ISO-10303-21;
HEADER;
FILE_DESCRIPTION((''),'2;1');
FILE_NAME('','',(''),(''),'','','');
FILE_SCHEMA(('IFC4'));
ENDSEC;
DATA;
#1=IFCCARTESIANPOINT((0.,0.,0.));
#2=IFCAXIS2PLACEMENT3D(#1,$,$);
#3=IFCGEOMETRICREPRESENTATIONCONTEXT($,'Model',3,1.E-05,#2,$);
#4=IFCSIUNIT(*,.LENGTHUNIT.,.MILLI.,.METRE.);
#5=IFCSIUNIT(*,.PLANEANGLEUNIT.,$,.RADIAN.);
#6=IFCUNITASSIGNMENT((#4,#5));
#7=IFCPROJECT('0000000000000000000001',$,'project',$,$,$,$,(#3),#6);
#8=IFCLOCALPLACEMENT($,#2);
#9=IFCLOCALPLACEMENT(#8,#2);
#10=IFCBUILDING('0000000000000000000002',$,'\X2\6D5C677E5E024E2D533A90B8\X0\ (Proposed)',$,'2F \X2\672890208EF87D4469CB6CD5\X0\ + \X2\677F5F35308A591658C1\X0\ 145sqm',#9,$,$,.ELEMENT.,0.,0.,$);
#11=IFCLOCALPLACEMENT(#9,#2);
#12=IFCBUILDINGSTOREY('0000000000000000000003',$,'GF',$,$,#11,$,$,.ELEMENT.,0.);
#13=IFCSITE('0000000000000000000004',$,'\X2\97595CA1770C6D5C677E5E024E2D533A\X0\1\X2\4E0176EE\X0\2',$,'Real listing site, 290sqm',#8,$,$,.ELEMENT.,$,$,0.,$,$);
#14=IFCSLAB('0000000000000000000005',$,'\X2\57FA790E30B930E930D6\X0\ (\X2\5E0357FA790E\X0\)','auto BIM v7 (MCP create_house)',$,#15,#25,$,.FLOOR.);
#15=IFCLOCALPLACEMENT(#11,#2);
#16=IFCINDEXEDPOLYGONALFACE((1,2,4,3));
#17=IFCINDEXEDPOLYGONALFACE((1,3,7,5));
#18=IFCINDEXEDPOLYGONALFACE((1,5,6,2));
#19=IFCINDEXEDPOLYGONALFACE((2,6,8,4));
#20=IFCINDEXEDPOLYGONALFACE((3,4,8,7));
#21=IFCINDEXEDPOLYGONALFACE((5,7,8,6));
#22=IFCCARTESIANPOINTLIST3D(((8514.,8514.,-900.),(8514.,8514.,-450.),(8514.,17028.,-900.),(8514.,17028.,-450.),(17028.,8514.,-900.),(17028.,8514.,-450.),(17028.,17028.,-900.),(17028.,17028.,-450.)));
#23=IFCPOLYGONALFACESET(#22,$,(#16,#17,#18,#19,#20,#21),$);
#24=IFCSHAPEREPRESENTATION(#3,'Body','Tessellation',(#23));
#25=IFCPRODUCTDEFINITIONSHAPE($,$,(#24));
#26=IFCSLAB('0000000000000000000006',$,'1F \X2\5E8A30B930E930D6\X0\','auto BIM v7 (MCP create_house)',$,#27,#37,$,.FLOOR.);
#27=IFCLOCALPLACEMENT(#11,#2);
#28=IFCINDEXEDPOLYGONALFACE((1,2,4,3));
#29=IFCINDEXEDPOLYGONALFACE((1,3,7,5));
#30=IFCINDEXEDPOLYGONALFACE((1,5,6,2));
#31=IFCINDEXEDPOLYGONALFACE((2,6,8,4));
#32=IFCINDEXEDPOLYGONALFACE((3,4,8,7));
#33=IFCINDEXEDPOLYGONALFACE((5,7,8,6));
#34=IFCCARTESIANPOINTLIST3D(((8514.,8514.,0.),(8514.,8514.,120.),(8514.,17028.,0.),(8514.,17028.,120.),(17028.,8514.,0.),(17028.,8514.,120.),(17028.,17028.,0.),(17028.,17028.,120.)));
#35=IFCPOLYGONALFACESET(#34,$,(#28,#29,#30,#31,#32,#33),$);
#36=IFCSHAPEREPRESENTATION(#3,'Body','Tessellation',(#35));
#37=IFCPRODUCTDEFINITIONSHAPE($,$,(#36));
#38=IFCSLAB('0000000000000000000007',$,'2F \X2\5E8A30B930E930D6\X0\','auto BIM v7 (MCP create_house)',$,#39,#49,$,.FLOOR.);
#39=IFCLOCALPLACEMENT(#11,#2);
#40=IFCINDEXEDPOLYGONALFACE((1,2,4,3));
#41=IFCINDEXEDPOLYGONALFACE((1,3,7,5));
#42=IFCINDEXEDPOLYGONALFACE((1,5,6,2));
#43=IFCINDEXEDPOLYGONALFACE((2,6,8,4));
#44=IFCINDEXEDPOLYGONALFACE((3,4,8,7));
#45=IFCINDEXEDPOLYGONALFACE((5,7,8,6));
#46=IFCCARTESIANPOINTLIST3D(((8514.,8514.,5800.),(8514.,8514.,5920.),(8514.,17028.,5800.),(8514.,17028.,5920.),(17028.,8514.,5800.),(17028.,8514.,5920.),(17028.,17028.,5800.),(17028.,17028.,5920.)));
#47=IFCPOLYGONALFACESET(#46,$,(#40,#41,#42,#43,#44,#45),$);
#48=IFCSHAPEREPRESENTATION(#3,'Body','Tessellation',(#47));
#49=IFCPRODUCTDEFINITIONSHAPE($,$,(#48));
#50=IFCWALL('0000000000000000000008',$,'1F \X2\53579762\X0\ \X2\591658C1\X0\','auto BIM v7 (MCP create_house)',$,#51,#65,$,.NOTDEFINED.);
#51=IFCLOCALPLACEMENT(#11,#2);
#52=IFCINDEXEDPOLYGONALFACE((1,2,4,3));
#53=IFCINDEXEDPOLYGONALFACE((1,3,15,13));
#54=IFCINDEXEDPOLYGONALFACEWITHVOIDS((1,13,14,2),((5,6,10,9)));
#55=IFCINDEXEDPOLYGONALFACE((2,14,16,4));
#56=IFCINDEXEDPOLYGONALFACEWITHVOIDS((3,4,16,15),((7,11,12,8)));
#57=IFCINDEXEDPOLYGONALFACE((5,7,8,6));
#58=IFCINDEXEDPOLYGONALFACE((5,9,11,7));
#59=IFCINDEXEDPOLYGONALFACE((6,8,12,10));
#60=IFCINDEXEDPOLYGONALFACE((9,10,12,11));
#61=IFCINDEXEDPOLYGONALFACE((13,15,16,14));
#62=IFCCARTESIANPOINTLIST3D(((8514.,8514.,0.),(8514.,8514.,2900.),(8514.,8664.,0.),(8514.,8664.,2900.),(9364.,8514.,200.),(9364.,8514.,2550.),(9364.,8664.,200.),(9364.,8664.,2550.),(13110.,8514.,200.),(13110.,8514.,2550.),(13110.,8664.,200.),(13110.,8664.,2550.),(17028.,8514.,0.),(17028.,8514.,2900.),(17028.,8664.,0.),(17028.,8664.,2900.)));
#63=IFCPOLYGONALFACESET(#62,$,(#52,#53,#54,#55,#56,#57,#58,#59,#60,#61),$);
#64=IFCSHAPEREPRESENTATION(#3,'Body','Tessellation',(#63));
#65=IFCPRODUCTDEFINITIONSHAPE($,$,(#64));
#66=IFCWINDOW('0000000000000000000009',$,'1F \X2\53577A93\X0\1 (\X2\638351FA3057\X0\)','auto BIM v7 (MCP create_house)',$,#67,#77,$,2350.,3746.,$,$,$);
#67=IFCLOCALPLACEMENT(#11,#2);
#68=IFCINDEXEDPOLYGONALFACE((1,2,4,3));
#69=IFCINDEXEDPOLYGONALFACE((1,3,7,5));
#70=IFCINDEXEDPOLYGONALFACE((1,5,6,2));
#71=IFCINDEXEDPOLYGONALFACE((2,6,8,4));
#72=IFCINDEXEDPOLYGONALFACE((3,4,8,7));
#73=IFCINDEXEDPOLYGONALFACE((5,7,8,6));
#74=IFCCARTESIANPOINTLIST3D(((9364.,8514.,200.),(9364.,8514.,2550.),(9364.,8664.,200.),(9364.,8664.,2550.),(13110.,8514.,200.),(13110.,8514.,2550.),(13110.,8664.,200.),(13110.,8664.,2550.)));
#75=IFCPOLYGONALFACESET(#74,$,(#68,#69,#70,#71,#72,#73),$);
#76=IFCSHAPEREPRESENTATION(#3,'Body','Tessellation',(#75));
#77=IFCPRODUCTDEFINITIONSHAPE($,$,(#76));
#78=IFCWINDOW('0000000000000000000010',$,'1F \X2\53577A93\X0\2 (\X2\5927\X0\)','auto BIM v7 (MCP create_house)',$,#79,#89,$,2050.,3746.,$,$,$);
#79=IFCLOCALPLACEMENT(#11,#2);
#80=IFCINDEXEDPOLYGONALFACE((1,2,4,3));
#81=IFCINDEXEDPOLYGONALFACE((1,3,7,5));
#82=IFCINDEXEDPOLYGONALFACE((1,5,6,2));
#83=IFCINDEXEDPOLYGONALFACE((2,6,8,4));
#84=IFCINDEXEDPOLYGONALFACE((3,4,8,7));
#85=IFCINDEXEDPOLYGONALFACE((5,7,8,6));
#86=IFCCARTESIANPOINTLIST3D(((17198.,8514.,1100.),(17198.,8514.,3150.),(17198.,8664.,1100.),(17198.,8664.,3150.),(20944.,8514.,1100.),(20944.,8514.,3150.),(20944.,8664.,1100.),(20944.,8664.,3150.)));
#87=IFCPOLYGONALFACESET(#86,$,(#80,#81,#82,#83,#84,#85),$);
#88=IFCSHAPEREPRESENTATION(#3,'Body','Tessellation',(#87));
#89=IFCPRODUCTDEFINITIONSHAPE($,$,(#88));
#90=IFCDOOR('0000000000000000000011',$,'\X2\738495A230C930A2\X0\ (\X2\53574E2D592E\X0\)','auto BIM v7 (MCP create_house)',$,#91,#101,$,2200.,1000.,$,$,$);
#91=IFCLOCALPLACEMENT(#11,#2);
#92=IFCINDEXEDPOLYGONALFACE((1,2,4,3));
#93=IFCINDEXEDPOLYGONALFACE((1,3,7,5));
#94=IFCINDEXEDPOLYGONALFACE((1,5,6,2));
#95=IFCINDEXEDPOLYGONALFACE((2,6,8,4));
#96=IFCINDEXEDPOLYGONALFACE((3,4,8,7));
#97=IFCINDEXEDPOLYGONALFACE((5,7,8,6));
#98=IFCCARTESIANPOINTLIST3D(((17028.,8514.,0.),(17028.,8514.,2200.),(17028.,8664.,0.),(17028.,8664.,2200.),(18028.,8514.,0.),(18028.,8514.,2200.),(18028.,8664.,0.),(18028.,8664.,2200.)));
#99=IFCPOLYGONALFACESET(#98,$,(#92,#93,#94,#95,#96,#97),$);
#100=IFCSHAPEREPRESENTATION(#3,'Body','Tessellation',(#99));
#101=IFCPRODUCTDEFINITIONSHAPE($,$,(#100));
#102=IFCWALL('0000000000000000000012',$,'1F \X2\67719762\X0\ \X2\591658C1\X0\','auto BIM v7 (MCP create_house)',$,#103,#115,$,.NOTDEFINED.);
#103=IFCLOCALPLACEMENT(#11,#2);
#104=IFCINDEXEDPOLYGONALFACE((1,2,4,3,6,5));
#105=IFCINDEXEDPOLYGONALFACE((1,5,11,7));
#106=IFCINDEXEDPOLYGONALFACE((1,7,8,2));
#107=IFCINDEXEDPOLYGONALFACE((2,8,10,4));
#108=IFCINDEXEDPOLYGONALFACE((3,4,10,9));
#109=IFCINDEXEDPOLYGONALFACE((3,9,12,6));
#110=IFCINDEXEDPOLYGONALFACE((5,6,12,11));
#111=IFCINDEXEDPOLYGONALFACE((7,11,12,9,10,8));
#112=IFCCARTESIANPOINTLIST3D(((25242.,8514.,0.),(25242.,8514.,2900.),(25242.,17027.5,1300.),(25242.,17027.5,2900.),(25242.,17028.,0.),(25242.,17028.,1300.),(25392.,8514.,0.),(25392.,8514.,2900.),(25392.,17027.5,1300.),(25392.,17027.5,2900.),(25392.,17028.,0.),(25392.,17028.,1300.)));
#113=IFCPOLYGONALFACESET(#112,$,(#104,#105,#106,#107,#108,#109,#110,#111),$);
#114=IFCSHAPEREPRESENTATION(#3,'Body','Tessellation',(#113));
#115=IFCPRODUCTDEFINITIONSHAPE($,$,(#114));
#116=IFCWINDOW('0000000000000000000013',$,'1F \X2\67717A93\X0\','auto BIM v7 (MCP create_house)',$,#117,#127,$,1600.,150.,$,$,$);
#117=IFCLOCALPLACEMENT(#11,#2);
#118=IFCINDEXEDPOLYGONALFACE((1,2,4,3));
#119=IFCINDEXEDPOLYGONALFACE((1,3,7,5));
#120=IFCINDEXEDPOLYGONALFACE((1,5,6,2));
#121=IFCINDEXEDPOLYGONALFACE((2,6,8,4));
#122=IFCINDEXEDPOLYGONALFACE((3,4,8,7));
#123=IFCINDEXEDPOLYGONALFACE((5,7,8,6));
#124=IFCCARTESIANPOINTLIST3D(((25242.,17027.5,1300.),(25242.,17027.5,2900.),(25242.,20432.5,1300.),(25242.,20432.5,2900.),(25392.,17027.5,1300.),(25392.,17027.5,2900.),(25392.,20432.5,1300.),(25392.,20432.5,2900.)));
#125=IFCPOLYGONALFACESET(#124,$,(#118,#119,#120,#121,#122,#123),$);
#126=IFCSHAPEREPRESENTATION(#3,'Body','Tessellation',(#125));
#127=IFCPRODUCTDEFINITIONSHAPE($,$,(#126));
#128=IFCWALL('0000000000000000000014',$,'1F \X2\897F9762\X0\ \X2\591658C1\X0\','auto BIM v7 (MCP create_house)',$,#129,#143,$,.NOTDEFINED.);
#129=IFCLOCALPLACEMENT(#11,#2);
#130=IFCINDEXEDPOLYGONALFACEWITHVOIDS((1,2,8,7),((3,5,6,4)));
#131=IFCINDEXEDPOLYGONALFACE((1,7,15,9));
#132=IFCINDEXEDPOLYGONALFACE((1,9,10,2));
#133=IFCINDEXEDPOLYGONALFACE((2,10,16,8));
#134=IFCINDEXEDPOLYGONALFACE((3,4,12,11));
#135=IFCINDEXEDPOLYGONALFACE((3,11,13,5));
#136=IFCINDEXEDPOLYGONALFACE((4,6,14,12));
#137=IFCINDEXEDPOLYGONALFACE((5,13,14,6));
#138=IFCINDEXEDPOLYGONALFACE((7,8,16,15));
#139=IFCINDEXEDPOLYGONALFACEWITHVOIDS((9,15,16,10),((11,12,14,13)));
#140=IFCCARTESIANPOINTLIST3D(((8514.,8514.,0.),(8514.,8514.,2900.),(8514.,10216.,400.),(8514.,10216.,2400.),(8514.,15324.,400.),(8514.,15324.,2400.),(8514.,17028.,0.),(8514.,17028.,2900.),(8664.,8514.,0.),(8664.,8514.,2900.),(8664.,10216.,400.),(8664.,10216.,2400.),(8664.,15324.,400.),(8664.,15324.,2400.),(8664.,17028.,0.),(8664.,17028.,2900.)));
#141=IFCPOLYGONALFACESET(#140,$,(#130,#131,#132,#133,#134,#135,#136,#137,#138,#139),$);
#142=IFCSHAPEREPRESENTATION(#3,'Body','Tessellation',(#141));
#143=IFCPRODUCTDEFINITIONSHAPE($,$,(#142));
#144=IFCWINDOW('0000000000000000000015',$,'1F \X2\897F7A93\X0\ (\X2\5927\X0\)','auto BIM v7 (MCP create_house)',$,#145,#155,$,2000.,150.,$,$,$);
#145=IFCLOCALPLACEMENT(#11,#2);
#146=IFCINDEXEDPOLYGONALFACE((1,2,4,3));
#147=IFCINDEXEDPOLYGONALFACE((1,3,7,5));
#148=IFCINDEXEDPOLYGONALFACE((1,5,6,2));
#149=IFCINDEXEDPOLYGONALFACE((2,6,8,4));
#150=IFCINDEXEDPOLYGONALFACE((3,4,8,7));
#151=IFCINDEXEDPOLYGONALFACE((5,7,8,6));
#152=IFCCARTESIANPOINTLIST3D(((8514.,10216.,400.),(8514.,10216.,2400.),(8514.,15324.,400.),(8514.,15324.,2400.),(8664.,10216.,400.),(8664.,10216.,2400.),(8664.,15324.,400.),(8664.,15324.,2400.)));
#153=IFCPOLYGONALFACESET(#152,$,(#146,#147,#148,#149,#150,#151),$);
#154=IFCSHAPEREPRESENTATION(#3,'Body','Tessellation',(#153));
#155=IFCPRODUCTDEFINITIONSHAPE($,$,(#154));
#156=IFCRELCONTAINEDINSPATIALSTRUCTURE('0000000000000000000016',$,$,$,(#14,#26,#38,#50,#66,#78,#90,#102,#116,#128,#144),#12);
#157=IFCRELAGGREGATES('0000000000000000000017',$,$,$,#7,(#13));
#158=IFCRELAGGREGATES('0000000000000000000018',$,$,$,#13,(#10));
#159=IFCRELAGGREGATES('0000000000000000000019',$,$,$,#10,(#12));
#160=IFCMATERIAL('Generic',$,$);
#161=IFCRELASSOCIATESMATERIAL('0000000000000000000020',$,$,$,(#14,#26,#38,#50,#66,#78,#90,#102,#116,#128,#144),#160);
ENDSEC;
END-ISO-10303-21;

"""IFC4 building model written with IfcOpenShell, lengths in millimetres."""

from ifc_helpers import new_model, si_unit, frame, frame_2d, origin, place, context, project, spatial, rectangle, extrude, material, element, fill, save


model = new_model("IFC4")

# Units and contexts
model_context = context("Model", 3, precision=1e-05, world=origin())
ifc_project = project(units=[si_unit("LENGTHUNIT", "METRE", prefix="MILLI"), si_unit("PLANEANGLEUNIT", "RADIAN")], contexts=[model_context])

# Site, building, storey
site_placement = place(None, origin())
site = spatial("IfcSite", under=ifc_project, at=site_placement, Name="静岡県浜松市中区1丁目2", ObjectType="Real listing site, 290sqm", CompositionType="ELEMENT", RefElevation=0.0)
building_placement = place(site_placement, origin())
building = spatial("IfcBuilding", under=site, at=building_placement, Name="浜松市中区邸 (Proposed)", ObjectType="2F 木造軸組構法 + 板張り外壁 145sqm", CompositionType="ELEMENT", ElevationOfRefHeight=0.0, ElevationOfTerrain=0.0)
storey_placement = place(building_placement, origin())
storey = spatial("IfcBuildingStorey", under=building, at=storey_placement, Name="GF", CompositionType="ELEMENT", Elevation=0.0)

# Slabs
ifc_material = material(Name="Generic")
slab_1_placement = place(storey_placement, frame((4257.0, 4257.0, -450.0)))
element("IfcSlab", 1, at=slab_1_placement, inside=storey, material=ifc_material, Name="基礎スラブ (布基礎)", Description="auto BIM v7 (MCP create_house)", PredefinedType="FLOOR", context=model_context, shape_type="SweptSolid", body=[
    extrude(rectangle(XDim=8514.0, YDim=8514.0, at=frame_2d((4257.0, 4257.0))), frame((4257.0, 4257.0, -450.0)), (0.0, 0.0, 1.0), 450.0),
])
slab_2_placement = place(storey_placement, frame((4257.0, 4257.0, 0.0)))
element("IfcSlab", 2, at=slab_2_placement, inside=storey, material=ifc_material, Name="1F 床スラブ", Description="auto BIM v7 (MCP create_house)", PredefinedType="FLOOR", context=model_context, shape_type="SweptSolid", body=[
    extrude(rectangle(XDim=8514.0, YDim=8514.0, at=frame_2d((4257.0, 4257.0))), frame((4257.0, 4257.0, 0.0)), (0.0, 0.0, 1.0), 120.0),
])
slab_3_placement = place(storey_placement, frame((4257.0, 4257.0, 2900.0)))
element("IfcSlab", 3, at=slab_3_placement, inside=storey, material=ifc_material, Name="2F 床スラブ", Description="auto BIM v7 (MCP create_house)", PredefinedType="FLOOR", context=model_context, shape_type="SweptSolid", body=[
    extrude(rectangle(XDim=8514.0, YDim=8514.0, at=frame_2d((4257.0, 4257.0))), frame((4257.0, 4257.0, 2900.0)), (0.0, 0.0, 1.0), 120.0),
])

# Wall, openings, windows, door
wall_1_placement = place(storey_placement, frame((4257.0, 4257.0, 0.0)))
wall_1 = element("IfcWall", 4, at=wall_1_placement, inside=storey, material=ifc_material, Name="1F 南面 外壁", Description="auto BIM v7 (MCP create_house)", PredefinedType="NOTDEFINED", context=model_context, shape_type="SweptSolid", body=[
    extrude(rectangle(XDim=8514.0, YDim=150.0, at=frame_2d((4257.0, 75.0))), frame((4257.0, 4257.0, 0.0)), (0.0, 0.0, 1.0), 2900.0),
])
opening_1_placement = place(storey_placement, frame((4682.0, 4257.0, 100.0)))
opening_1 = element("IfcOpeningElement", 5, at=opening_1_placement, cuts=wall_1, PredefinedType="NOTDEFINED", context=model_context, shape_type="SweptSolid", body=[
    extrude(rectangle(XDim=3746.0, YDim=150.0, at=frame_2d((1873.0, 75.0))), frame((4682.0, 4257.0, 100.0)), (0.0, 0.0, 1.0), 2350.0),
])
opening_2_placement = place(storey_placement, frame((8599.0, 4257.0, 550.0)))
opening_2 = element("IfcOpeningElement", 6, at=opening_2_placement, cuts=wall_1, PredefinedType="NOTDEFINED", context=model_context, shape_type="SweptSolid", body=[
    extrude(rectangle(XDim=3746.0, YDim=150.0, at=frame_2d((1873.0, 75.0))), frame((8599.0, 4257.0, 550.0)), (0.0, 0.0, 1.0), 2050.0),
])
opening_3_placement = place(storey_placement, frame((8514.0, 4257.0, 0.0)))
opening_3 = element("IfcOpeningElement", 7, at=opening_3_placement, cuts=wall_1, PredefinedType="NOTDEFINED", context=model_context, shape_type="SweptSolid", body=[
    extrude(rectangle(XDim=1000.0, YDim=150.0, at=frame_2d((500.0, 75.0))), frame((8514.0, 4257.0, 0.0)), (0.0, 0.0, 1.0), 2200.0),
])
window_1_placement = place(storey_placement, frame((4682.0, 4257.0, 100.0)))
window_1 = element("IfcWindow", 8, at=window_1_placement, inside=storey, material=ifc_material, Name="1F 南窓1 (掃出し)", Description="auto BIM v7 (MCP create_house)", OverallHeight=2350.0, OverallWidth=3746.0, context=model_context, shape_type="SweptSolid", body=[
    extrude(rectangle(XDim=3746.0, YDim=150.0, at=frame_2d((1873.0, 75.0))), frame((4682.0, 4257.0, 100.0)), (0.0, 0.0, 1.0), 2350.0),
])
fill(opening_1, window_1)
window_2_placement = place(storey_placement, frame((8599.0, 4257.0, 550.0)))
window_2 = element("IfcWindow", 9, at=window_2_placement, inside=storey, material=ifc_material, Name="1F 南窓2 (大)", Description="auto BIM v7 (MCP create_house)", OverallHeight=2050.0, OverallWidth=3746.0, context=model_context, shape_type="SweptSolid", body=[
    extrude(rectangle(XDim=3746.0, YDim=150.0, at=frame_2d((1873.0, 75.0))), frame((8599.0, 4257.0, 550.0)), (0.0, 0.0, 1.0), 2050.0),
])
fill(opening_2, window_2)
door_placement = place(storey_placement, frame((8514.0, 4257.0, 0.0)))
door = element("IfcDoor", 10, at=door_placement, inside=storey, material=ifc_material, Name="玄関ドア (南中央)", Description="auto BIM v7 (MCP create_house)", OverallHeight=2200.0, OverallWidth=1000.0, context=model_context, shape_type="SweptSolid", body=[
    extrude(rectangle(XDim=1000.0, YDim=150.0, at=frame_2d((500.0, 75.0))), frame((8514.0, 4257.0, 0.0)), (0.0, 0.0, 1.0), 2200.0),
])
fill(opening_3, door)

# Walls, openings, windows
wall_2_placement = place(storey_placement, frame((12621.0, 4257.0, 0.0)))
wall_2 = element("IfcWall", 11, at=wall_2_placement, inside=storey, material=ifc_material, Name="1F 東面 外壁", Description="auto BIM v7 (MCP create_house)", PredefinedType="NOTDEFINED", context=model_context, shape_type="SweptSolid", body=[
    extrude(rectangle(XDim=150.0, YDim=8514.0, at=frame_2d((75.0, 4257.0))), frame((12621.0, 4257.0, 0.0)), (0.0, 0.0, 1.0), 2900.0),
])
opening_4_placement = place(storey_placement, frame((12621.0, 8514.0, 650.0)))
opening_4 = element("IfcOpeningElement", 12, at=opening_4_placement, cuts=wall_2, PredefinedType="NOTDEFINED", context=model_context, shape_type="SweptSolid", body=[
    extrude(rectangle(XDim=150.0, YDim=3405.0, at=frame_2d((75.0, 1702.0))), frame((12621.0, 8514.0, 650.0)), (0.0, 0.0, 1.0), 1600.0),
])
window_3_placement = place(storey_placement, frame((12621.0, 8514.0, 650.0)))
window_3 = element("IfcWindow", 13, at=window_3_placement, inside=storey, material=ifc_material, Name="1F 東窓", Description="auto BIM v7 (MCP create_house)", OverallHeight=1600.0, OverallWidth=150.0, context=model_context, shape_type="SweptSolid", body=[
    extrude(rectangle(XDim=150.0, YDim=3405.0, at=frame_2d((75.0, 1702.0))), frame((12621.0, 8514.0, 650.0)), (0.0, 0.0, 1.0), 1600.0),
])
fill(opening_4, window_3)
wall_3_placement = place(storey_placement, frame((4257.0, 4257.0, 0.0)))
wall_3 = element("IfcWall", 14, at=wall_3_placement, inside=storey, material=ifc_material, Name="1F 西面 外壁", Description="auto BIM v7 (MCP create_house)", PredefinedType="NOTDEFINED", context=model_context, shape_type="SweptSolid", body=[
    extrude(rectangle(XDim=150.0, YDim=8514.0, at=frame_2d((75.0, 4257.0))), frame((4257.0, 4257.0, 0.0)), (0.0, 0.0, 1.0), 2900.0),
])
opening_5_placement = place(storey_placement, frame((4257.0, 5108.0, 200.0)))
opening_5 = element("IfcOpeningElement", 15, at=opening_5_placement, cuts=wall_3, PredefinedType="NOTDEFINED", context=model_context, shape_type="SweptSolid", body=[
    extrude(rectangle(XDim=150.0, YDim=5108.0, at=frame_2d((75.0, 2554.0))), frame((4257.0, 5108.0, 200.0)), (0.0, 0.0, 1.0), 2000.0),
])
window_4_placement = place(storey_placement, frame((4257.0, 5108.0, 200.0)))
window_4 = element("IfcWindow", 16, at=window_4_placement, inside=storey, material=ifc_material, Name="1F 西窓 (大)", Description="auto BIM v7 (MCP create_house)", OverallHeight=2000.0, OverallWidth=150.0, context=model_context, shape_type="SweptSolid", body=[
    extrude(rectangle(XDim=150.0, YDim=5108.0, at=frame_2d((75.0, 2554.0))), frame((4257.0, 5108.0, 200.0)), (0.0, 0.0, 1.0), 2000.0),
])
fill(opening_5, window_4)

save(model, "model.ifc")
